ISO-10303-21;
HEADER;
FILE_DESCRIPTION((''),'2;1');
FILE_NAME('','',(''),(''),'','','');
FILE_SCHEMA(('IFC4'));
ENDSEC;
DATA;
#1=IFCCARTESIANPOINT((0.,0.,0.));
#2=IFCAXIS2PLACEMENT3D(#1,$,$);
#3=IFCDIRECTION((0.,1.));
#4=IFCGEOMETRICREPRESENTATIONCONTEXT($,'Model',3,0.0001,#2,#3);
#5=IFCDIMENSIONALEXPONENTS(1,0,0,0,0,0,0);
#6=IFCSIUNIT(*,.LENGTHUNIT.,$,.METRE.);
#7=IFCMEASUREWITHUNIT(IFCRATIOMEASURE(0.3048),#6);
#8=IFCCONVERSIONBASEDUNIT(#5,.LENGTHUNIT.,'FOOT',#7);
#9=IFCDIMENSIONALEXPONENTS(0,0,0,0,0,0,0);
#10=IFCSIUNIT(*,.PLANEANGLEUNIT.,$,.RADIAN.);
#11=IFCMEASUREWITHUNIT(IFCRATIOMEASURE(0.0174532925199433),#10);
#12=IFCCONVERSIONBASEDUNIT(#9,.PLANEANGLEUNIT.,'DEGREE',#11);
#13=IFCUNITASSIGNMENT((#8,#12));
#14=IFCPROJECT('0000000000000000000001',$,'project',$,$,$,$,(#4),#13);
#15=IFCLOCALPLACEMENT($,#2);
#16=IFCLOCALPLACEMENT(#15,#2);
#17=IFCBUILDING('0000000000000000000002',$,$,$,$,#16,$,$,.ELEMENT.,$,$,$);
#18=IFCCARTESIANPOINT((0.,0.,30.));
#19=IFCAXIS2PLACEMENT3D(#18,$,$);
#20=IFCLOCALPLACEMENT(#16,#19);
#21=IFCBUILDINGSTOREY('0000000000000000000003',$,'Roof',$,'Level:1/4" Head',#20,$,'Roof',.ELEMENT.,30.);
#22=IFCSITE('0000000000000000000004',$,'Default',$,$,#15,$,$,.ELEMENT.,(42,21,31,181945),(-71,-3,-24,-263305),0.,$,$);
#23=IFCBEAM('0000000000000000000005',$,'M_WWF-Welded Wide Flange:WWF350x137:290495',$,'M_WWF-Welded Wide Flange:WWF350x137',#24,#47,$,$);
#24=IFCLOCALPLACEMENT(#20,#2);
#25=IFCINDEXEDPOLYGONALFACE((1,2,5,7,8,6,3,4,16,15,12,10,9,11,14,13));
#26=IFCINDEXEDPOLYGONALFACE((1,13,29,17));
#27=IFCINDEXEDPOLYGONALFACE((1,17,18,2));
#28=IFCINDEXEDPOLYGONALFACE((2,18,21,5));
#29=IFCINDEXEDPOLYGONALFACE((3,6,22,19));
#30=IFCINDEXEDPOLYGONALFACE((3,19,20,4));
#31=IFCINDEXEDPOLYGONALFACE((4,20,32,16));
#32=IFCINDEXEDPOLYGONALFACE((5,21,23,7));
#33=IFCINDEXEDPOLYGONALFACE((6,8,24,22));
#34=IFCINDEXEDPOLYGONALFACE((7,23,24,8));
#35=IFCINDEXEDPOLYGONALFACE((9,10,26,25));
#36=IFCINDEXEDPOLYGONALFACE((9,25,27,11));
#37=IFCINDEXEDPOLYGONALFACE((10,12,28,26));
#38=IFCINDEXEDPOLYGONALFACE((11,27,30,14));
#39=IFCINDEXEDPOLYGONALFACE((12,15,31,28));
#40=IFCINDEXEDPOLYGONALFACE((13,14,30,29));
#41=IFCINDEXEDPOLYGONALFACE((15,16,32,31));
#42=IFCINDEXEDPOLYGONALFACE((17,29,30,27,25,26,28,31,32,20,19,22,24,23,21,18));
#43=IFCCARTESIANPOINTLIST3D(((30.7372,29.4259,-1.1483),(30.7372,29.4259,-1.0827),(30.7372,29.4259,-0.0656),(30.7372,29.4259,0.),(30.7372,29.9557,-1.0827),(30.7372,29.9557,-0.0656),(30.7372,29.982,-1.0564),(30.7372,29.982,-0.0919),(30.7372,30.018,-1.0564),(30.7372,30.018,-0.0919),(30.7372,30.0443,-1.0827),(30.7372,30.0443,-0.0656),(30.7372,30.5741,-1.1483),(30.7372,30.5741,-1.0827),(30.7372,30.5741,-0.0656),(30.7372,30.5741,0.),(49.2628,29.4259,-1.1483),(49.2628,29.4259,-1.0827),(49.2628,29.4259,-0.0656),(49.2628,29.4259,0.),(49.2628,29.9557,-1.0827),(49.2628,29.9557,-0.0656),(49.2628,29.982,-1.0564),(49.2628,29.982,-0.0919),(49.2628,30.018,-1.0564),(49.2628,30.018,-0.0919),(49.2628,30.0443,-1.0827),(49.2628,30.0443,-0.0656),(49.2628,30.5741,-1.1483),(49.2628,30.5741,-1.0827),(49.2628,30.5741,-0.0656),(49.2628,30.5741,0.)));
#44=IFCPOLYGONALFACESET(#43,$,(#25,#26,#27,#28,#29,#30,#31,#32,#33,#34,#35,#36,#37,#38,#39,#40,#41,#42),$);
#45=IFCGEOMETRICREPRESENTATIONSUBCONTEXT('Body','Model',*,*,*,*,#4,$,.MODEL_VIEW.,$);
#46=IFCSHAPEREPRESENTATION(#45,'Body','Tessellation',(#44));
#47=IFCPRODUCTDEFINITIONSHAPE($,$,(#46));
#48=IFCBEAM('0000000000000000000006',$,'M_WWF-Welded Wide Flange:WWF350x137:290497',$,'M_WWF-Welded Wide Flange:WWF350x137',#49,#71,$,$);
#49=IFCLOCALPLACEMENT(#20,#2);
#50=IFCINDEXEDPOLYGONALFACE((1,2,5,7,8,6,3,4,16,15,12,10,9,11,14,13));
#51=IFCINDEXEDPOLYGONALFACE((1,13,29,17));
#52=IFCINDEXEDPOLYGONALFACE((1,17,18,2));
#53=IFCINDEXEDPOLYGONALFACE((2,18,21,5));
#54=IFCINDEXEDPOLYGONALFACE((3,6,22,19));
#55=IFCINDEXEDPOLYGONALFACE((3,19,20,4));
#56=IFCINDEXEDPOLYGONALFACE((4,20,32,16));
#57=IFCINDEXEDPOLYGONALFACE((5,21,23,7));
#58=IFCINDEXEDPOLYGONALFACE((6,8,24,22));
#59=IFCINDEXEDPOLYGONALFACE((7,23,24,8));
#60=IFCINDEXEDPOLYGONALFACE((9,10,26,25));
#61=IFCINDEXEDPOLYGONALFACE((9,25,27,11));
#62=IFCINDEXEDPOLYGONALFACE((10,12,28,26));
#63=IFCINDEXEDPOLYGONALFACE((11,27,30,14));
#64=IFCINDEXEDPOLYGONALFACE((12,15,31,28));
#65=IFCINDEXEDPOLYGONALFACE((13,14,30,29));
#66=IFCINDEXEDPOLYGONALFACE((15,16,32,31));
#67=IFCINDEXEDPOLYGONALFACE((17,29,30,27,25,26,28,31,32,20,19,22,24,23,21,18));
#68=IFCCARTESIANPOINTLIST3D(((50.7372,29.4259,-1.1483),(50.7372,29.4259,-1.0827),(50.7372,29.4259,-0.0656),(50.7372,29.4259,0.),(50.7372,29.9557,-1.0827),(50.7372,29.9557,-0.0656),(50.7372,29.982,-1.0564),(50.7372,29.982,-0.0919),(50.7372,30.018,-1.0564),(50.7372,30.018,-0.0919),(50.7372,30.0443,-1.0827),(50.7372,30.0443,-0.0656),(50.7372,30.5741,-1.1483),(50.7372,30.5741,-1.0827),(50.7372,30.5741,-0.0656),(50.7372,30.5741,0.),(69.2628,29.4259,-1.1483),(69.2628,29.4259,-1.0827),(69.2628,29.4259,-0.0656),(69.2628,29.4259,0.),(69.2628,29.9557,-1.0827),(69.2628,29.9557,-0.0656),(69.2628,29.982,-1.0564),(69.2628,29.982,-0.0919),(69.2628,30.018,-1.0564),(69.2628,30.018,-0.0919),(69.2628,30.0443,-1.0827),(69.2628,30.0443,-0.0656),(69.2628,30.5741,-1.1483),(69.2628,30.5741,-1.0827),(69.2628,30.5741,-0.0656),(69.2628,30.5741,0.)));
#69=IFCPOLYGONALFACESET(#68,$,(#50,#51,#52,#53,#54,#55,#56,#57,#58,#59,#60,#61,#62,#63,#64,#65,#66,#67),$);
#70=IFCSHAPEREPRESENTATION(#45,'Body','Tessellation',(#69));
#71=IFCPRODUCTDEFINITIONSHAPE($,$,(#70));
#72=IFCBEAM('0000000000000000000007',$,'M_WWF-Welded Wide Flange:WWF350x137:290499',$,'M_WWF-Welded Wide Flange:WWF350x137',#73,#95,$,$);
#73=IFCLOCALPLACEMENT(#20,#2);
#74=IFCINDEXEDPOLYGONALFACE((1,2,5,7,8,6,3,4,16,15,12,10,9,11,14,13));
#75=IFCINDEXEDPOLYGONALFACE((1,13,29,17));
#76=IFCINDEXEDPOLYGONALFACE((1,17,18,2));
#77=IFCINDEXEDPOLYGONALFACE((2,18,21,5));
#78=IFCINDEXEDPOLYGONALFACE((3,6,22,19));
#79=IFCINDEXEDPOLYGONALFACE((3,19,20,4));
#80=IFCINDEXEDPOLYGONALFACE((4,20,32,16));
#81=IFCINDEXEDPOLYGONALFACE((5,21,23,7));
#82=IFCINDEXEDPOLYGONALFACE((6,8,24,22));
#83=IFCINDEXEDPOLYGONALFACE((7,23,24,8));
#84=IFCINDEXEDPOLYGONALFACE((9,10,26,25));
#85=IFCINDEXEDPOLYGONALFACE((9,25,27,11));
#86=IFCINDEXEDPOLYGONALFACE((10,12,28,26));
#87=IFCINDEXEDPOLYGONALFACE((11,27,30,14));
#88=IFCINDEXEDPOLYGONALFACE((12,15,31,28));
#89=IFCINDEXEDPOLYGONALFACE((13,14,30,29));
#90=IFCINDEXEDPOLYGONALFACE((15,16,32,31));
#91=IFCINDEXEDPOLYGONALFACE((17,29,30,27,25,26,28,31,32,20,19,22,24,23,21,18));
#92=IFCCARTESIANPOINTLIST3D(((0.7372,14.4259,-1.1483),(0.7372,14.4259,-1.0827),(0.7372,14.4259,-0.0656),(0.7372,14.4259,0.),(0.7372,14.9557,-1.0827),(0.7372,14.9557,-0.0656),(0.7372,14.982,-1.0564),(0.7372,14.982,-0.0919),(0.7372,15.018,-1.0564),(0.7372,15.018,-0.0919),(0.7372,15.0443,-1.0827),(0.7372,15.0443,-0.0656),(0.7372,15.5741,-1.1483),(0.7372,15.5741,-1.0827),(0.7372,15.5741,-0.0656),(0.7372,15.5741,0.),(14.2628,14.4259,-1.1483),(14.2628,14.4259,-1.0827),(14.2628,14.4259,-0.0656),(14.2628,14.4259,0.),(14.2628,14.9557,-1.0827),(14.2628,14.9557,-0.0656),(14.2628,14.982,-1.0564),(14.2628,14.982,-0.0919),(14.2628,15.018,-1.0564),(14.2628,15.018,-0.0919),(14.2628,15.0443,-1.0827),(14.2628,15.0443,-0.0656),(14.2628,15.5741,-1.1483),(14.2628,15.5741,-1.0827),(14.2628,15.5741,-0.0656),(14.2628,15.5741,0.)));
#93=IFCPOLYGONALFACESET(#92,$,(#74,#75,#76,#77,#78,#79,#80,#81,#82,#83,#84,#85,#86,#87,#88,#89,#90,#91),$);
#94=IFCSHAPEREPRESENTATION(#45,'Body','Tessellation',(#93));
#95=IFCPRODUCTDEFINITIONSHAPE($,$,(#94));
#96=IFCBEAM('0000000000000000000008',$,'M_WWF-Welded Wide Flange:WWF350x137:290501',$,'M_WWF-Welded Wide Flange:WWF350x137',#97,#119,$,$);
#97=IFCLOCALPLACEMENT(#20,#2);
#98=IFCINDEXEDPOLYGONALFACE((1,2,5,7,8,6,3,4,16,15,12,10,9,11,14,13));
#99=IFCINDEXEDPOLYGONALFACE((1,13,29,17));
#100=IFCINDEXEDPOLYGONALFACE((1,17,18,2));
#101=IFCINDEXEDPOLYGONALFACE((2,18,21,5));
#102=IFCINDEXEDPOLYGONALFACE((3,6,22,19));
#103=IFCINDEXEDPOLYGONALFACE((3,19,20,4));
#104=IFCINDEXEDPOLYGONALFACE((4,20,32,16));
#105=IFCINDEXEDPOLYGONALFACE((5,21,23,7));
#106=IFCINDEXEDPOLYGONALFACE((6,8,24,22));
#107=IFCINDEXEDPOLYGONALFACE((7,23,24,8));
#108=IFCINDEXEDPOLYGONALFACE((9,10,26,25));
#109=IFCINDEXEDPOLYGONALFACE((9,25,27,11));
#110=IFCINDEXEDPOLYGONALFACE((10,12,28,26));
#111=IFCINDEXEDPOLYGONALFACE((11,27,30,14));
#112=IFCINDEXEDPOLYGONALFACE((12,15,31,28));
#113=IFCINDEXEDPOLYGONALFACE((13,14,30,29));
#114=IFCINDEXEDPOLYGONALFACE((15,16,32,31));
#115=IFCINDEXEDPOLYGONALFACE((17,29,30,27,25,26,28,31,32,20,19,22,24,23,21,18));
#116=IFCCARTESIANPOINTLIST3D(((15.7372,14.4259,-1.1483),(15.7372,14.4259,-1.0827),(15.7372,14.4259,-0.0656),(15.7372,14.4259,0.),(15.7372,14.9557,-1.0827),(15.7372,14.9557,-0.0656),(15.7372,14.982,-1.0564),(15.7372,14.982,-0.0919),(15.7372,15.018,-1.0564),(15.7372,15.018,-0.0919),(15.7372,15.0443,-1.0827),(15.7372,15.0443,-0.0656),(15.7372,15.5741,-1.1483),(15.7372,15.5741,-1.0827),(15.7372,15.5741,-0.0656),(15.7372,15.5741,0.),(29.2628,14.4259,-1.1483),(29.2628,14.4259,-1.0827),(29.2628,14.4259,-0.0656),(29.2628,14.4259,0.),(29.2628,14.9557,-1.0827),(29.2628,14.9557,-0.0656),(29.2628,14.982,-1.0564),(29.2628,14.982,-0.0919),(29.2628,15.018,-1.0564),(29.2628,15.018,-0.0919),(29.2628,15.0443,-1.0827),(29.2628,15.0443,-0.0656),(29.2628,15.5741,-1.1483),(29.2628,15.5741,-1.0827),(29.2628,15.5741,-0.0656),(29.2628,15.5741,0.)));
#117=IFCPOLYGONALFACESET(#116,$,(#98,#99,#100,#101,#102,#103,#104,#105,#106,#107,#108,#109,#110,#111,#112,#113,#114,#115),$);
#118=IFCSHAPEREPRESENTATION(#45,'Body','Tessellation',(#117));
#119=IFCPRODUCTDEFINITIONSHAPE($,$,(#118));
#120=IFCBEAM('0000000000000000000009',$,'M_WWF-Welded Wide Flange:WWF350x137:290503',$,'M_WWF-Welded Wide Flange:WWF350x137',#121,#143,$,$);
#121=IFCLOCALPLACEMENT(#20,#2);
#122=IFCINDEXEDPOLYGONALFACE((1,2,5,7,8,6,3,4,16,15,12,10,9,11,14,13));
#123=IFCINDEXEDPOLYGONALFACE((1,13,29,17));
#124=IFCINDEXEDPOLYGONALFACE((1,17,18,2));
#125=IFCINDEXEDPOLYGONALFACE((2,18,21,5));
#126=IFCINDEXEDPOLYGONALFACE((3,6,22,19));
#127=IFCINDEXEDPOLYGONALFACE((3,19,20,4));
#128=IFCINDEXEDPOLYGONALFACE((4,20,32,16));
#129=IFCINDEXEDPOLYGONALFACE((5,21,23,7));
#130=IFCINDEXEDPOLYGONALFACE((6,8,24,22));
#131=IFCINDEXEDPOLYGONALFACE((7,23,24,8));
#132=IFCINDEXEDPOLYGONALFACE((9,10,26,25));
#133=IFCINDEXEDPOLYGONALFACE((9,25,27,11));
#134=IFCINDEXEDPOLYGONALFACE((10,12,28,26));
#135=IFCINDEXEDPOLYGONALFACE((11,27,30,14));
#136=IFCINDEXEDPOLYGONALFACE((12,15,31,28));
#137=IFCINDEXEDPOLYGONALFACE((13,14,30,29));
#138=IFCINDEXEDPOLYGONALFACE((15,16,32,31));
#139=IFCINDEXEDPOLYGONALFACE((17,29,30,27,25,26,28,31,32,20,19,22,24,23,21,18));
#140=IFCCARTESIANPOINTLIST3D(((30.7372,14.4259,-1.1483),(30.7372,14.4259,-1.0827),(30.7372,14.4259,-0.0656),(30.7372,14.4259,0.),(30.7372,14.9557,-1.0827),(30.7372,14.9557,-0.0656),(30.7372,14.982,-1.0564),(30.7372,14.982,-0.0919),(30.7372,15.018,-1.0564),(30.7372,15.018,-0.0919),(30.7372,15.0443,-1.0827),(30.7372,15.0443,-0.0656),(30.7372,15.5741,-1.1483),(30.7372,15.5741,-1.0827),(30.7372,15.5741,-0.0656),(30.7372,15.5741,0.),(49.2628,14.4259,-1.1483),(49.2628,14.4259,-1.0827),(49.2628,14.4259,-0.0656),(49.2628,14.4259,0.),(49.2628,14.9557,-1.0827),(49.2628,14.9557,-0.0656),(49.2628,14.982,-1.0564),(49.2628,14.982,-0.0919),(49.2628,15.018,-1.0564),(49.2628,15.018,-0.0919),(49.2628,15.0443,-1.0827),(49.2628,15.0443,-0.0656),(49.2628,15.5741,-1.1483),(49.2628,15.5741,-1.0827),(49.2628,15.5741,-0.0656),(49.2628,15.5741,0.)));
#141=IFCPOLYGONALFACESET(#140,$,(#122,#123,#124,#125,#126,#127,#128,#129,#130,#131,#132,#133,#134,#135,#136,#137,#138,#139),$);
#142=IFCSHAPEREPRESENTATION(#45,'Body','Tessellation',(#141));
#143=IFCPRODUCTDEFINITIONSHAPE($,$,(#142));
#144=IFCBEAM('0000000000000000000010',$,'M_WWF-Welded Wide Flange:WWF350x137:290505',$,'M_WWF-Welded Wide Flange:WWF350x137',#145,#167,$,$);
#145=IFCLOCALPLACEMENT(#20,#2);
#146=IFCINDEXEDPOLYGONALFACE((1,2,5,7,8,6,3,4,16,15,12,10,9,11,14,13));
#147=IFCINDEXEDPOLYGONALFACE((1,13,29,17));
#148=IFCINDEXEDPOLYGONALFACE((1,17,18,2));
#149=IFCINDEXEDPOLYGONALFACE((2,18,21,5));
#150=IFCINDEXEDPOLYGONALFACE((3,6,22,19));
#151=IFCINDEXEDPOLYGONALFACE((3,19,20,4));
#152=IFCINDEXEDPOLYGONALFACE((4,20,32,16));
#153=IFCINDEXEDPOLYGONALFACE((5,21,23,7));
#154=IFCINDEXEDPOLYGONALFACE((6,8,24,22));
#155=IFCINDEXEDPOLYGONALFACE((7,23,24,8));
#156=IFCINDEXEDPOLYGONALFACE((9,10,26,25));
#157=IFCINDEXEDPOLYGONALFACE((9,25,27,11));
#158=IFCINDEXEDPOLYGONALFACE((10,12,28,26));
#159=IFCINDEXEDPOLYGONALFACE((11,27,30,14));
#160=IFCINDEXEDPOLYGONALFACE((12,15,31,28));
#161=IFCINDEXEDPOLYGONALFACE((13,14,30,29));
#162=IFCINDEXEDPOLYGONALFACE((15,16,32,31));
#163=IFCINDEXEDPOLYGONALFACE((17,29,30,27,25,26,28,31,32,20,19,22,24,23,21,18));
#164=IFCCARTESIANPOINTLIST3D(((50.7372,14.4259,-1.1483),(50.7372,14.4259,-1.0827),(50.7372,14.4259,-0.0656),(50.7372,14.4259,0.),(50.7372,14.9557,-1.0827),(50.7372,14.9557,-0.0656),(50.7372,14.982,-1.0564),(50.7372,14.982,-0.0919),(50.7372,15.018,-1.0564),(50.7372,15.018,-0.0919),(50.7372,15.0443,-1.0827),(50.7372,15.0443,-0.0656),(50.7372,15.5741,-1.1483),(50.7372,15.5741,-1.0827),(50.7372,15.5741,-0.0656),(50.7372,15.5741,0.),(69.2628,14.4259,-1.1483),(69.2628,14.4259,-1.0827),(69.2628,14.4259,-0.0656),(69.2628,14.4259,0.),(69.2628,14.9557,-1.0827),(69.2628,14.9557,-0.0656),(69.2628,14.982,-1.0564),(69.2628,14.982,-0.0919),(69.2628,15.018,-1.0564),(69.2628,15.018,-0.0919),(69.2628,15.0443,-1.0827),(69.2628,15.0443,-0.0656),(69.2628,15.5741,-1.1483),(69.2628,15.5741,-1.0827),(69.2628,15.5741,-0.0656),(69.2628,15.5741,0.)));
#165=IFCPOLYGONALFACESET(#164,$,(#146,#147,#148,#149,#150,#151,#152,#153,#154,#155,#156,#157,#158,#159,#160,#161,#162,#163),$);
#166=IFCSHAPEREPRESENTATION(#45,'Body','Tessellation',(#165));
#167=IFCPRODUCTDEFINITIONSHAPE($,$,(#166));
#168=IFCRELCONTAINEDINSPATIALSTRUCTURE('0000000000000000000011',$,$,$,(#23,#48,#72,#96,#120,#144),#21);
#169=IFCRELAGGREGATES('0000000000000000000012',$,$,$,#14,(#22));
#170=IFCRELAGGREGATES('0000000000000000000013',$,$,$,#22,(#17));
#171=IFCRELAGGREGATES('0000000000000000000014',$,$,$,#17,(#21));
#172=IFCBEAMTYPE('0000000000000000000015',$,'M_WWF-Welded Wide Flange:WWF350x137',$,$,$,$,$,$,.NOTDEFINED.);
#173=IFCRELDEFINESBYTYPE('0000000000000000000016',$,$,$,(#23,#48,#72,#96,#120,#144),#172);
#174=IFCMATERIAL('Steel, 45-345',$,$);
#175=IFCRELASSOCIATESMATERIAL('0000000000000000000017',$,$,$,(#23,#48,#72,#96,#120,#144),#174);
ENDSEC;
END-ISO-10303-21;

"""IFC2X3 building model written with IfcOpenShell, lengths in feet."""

from ifc_helpers import new_model, entity, si_unit, converted_unit, direction, frame, origin, place, context, subcontext, project, spatial, polyline, outline, extrude, material, type_object, element, save


model = new_model("IFC2X3")

# Units and contexts
model_context = context("Model", 3, precision=0.0001, world=origin(), true_north=direction((0.0, 1.0)))
body_context = subcontext(model_context, "Body", "Model", "MODEL_VIEW")
ifc_project = project(units=[converted_unit("LENGTHUNIT", "FOOT", entity("IfcRatioMeasure", 0.3048), si_unit("LENGTHUNIT", "METRE"), dimensions=[1, 0, 0, 0, 0, 0, 0]), converted_unit("PLANEANGLEUNIT", "DEGREE", entity("IfcRatioMeasure", 0.0174532925199433), si_unit("PLANEANGLEUNIT", "RADIAN"), dimensions=[0, 0, 0, 0, 0, 0, 0])], contexts=[model_context])

# Site, building, storey
site_placement = place(None, origin())
site = spatial("IfcSite", under=ifc_project, at=site_placement, Name="Default", CompositionType="ELEMENT", RefLatitude=(42, 21, 31, 181945), RefLongitude=(-71, -3, -24, -263305), RefElevation=0.0)
building_placement = place(site_placement, origin())
building = spatial("IfcBuilding", under=site, at=building_placement, CompositionType="ELEMENT")
storey_placement = place(building_placement, frame((0.0, 0.0, 30.0)))
storey = spatial("IfcBuildingStorey", under=building, at=storey_placement, Name="Roof", ObjectType="Level:1/4\" Head", LongName="Roof", CompositionType="ELEMENT", Elevation=30.0)

# Beams
ifc_material = material(Name="Steel, 45-345")
beam_type = type_object("IfcBeamType", Name="M_WWF-Welded Wide Flange:WWF350x137", PredefinedType="NOTDEFINED")
beam_1_placement = place(storey_placement, frame((30.0, 30.0, 0.0)))
element("IfcBeam", 1, at=beam_1_placement, inside=storey, type_object=beam_type, material=ifc_material, Name="M_WWF-Welded Wide Flange:WWF350x137:290495", ObjectType="M_WWF-Welded Wide Flange:WWF350x137", context=body_context, shape_type="SweptSolid", body=[
    extrude(outline(polyline([(-0.5741, -0.5741), (-0.5085, -0.5741), (-0.5085, -0.0443), (-0.4823, -0.018), (0.4823, -0.018), (0.5085, -0.0443), (0.5085, -0.5741), (0.5741, -0.5741), (0.5741, 0.5741), (0.5085, 0.5741), (0.5085, 0.0443), (0.4823, 0.018), (-0.4823, 0.018), (-0.5085, 0.0443), (-0.5085, 0.5741), (-0.5741, 0.5741), (-0.5741, -0.5741)])), frame((0.7372, 0.0, -0.5741), z_axis=(1.0, 0.0, 0.0), x_axis=(0.0, 0.0, -1.0)), (0.0, 0.0, 1.0), 18.5256),
])
beam_2_placement = place(storey_placement, frame((50.0, 30.0, 0.0)))
element("IfcBeam", 2, at=beam_2_placement, inside=storey, type_object=beam_type, material=ifc_material, Name="M_WWF-Welded Wide Flange:WWF350x137:290497", ObjectType="M_WWF-Welded Wide Flange:WWF350x137", context=body_context, shape_type="SweptSolid", body=[
    extrude(outline(polyline([(-0.5741, -0.5741), (-0.5085, -0.5741), (-0.5085, -0.0443), (-0.4823, -0.018), (0.4823, -0.018), (0.5085, -0.0443), (0.5085, -0.5741), (0.5741, -0.5741), (0.5741, 0.5741), (0.5085, 0.5741), (0.5085, 0.0443), (0.4823, 0.018), (-0.4823, 0.018), (-0.5085, 0.0443), (-0.5085, 0.5741), (-0.5741, 0.5741), (-0.5741, -0.5741)])), frame((0.7372, 0.0, -0.5741), z_axis=(1.0, 0.0, 0.0), x_axis=(0.0, 0.0, -1.0)), (0.0, 0.0, 1.0), 18.5256),
])
beam_3_placement = place(storey_placement, frame((0.0, 15.0, 0.0)))
element("IfcBeam", 3, at=beam_3_placement, inside=storey, type_object=beam_type, material=ifc_material, Name="M_WWF-Welded Wide Flange:WWF350x137:290499", ObjectType="M_WWF-Welded Wide Flange:WWF350x137", context=body_context, shape_type="SweptSolid", body=[
    extrude(outline(polyline([(-0.5741, -0.5741), (-0.5085, -0.5741), (-0.5085, -0.0443), (-0.4823, -0.018), (0.4823, -0.018), (0.5085, -0.0443), (0.5085, -0.5741), (0.5741, -0.5741), (0.5741, 0.5741), (0.5085, 0.5741), (0.5085, 0.0443), (0.4823, 0.018), (-0.4823, 0.018), (-0.5085, 0.0443), (-0.5085, 0.5741), (-0.5741, 0.5741), (-0.5741, -0.5741)])), frame((0.7372, 0.0, -0.5741), z_axis=(1.0, 0.0, 0.0), x_axis=(0.0, 0.0, -1.0)), (0.0, 0.0, 1.0), 13.5256),
])
beam_4_placement = place(storey_placement, frame((15.0, 15.0, 0.0)))
element("IfcBeam", 4, at=beam_4_placement, inside=storey, type_object=beam_type, material=ifc_material, Name="M_WWF-Welded Wide Flange:WWF350x137:290501", ObjectType="M_WWF-Welded Wide Flange:WWF350x137", context=body_context, shape_type="SweptSolid", body=[
    extrude(outline(polyline([(-0.5741, -0.5741), (-0.5085, -0.5741), (-0.5085, -0.0443), (-0.4823, -0.018), (0.4823, -0.018), (0.5085, -0.0443), (0.5085, -0.5741), (0.5741, -0.5741), (0.5741, 0.5741), (0.5085, 0.5741), (0.5085, 0.0443), (0.4823, 0.018), (-0.4823, 0.018), (-0.5085, 0.0443), (-0.5085, 0.5741), (-0.5741, 0.5741), (-0.5741, -0.5741)])), frame((0.7372, 0.0, -0.5741), z_axis=(1.0, 0.0, 0.0), x_axis=(0.0, 0.0, -1.0)), (0.0, 0.0, 1.0), 13.5256),
])
beam_5_placement = place(storey_placement, frame((30.0, 15.0, 0.0)))
element("IfcBeam", 5, at=beam_5_placement, inside=storey, type_object=beam_type, material=ifc_material, Name="M_WWF-Welded Wide Flange:WWF350x137:290503", ObjectType="M_WWF-Welded Wide Flange:WWF350x137", context=body_context, shape_type="SweptSolid", body=[
    extrude(outline(polyline([(-0.5741, -0.5741), (-0.5085, -0.5741), (-0.5085, -0.0443), (-0.4823, -0.018), (0.4823, -0.018), (0.5085, -0.0443), (0.5085, -0.5741), (0.5741, -0.5741), (0.5741, 0.5741), (0.5085, 0.5741), (0.5085, 0.0443), (0.4823, 0.018), (-0.4823, 0.018), (-0.5085, 0.0443), (-0.5085, 0.5741), (-0.5741, 0.5741), (-0.5741, -0.5741)])), frame((0.7372, 0.0, -0.5741), z_axis=(1.0, 0.0, 0.0), x_axis=(0.0, 0.0, -1.0)), (0.0, 0.0, 1.0), 18.5256),
])
beam_6_placement = place(storey_placement, frame((50.0, 15.0, 0.0)))
element("IfcBeam", 6, at=beam_6_placement, inside=storey, type_object=beam_type, material=ifc_material, Name="M_WWF-Welded Wide Flange:WWF350x137:290505", ObjectType="M_WWF-Welded Wide Flange:WWF350x137", context=body_context, shape_type="SweptSolid", body=[
    extrude(outline(polyline([(-0.5741, -0.5741), (-0.5085, -0.5741), (-0.5085, -0.0443), (-0.4823, -0.018), (0.4823, -0.018), (0.5085, -0.0443), (0.5085, -0.5741), (0.5741, -0.5741), (0.5741, 0.5741), (0.5085, 0.5741), (0.5085, 0.0443), (0.4823, 0.018), (-0.4823, 0.018), (-0.5085, 0.0443), (-0.5085, 0.5741), (-0.5741, 0.5741), (-0.5741, -0.5741)])), frame((0.7372, 0.0, -0.5741), z_axis=(1.0, 0.0, 0.0), x_axis=(0.0, 0.0, -1.0)), (0.0, 0.0, 1.0), 18.5256),
])

save(model, "model.ifc")
